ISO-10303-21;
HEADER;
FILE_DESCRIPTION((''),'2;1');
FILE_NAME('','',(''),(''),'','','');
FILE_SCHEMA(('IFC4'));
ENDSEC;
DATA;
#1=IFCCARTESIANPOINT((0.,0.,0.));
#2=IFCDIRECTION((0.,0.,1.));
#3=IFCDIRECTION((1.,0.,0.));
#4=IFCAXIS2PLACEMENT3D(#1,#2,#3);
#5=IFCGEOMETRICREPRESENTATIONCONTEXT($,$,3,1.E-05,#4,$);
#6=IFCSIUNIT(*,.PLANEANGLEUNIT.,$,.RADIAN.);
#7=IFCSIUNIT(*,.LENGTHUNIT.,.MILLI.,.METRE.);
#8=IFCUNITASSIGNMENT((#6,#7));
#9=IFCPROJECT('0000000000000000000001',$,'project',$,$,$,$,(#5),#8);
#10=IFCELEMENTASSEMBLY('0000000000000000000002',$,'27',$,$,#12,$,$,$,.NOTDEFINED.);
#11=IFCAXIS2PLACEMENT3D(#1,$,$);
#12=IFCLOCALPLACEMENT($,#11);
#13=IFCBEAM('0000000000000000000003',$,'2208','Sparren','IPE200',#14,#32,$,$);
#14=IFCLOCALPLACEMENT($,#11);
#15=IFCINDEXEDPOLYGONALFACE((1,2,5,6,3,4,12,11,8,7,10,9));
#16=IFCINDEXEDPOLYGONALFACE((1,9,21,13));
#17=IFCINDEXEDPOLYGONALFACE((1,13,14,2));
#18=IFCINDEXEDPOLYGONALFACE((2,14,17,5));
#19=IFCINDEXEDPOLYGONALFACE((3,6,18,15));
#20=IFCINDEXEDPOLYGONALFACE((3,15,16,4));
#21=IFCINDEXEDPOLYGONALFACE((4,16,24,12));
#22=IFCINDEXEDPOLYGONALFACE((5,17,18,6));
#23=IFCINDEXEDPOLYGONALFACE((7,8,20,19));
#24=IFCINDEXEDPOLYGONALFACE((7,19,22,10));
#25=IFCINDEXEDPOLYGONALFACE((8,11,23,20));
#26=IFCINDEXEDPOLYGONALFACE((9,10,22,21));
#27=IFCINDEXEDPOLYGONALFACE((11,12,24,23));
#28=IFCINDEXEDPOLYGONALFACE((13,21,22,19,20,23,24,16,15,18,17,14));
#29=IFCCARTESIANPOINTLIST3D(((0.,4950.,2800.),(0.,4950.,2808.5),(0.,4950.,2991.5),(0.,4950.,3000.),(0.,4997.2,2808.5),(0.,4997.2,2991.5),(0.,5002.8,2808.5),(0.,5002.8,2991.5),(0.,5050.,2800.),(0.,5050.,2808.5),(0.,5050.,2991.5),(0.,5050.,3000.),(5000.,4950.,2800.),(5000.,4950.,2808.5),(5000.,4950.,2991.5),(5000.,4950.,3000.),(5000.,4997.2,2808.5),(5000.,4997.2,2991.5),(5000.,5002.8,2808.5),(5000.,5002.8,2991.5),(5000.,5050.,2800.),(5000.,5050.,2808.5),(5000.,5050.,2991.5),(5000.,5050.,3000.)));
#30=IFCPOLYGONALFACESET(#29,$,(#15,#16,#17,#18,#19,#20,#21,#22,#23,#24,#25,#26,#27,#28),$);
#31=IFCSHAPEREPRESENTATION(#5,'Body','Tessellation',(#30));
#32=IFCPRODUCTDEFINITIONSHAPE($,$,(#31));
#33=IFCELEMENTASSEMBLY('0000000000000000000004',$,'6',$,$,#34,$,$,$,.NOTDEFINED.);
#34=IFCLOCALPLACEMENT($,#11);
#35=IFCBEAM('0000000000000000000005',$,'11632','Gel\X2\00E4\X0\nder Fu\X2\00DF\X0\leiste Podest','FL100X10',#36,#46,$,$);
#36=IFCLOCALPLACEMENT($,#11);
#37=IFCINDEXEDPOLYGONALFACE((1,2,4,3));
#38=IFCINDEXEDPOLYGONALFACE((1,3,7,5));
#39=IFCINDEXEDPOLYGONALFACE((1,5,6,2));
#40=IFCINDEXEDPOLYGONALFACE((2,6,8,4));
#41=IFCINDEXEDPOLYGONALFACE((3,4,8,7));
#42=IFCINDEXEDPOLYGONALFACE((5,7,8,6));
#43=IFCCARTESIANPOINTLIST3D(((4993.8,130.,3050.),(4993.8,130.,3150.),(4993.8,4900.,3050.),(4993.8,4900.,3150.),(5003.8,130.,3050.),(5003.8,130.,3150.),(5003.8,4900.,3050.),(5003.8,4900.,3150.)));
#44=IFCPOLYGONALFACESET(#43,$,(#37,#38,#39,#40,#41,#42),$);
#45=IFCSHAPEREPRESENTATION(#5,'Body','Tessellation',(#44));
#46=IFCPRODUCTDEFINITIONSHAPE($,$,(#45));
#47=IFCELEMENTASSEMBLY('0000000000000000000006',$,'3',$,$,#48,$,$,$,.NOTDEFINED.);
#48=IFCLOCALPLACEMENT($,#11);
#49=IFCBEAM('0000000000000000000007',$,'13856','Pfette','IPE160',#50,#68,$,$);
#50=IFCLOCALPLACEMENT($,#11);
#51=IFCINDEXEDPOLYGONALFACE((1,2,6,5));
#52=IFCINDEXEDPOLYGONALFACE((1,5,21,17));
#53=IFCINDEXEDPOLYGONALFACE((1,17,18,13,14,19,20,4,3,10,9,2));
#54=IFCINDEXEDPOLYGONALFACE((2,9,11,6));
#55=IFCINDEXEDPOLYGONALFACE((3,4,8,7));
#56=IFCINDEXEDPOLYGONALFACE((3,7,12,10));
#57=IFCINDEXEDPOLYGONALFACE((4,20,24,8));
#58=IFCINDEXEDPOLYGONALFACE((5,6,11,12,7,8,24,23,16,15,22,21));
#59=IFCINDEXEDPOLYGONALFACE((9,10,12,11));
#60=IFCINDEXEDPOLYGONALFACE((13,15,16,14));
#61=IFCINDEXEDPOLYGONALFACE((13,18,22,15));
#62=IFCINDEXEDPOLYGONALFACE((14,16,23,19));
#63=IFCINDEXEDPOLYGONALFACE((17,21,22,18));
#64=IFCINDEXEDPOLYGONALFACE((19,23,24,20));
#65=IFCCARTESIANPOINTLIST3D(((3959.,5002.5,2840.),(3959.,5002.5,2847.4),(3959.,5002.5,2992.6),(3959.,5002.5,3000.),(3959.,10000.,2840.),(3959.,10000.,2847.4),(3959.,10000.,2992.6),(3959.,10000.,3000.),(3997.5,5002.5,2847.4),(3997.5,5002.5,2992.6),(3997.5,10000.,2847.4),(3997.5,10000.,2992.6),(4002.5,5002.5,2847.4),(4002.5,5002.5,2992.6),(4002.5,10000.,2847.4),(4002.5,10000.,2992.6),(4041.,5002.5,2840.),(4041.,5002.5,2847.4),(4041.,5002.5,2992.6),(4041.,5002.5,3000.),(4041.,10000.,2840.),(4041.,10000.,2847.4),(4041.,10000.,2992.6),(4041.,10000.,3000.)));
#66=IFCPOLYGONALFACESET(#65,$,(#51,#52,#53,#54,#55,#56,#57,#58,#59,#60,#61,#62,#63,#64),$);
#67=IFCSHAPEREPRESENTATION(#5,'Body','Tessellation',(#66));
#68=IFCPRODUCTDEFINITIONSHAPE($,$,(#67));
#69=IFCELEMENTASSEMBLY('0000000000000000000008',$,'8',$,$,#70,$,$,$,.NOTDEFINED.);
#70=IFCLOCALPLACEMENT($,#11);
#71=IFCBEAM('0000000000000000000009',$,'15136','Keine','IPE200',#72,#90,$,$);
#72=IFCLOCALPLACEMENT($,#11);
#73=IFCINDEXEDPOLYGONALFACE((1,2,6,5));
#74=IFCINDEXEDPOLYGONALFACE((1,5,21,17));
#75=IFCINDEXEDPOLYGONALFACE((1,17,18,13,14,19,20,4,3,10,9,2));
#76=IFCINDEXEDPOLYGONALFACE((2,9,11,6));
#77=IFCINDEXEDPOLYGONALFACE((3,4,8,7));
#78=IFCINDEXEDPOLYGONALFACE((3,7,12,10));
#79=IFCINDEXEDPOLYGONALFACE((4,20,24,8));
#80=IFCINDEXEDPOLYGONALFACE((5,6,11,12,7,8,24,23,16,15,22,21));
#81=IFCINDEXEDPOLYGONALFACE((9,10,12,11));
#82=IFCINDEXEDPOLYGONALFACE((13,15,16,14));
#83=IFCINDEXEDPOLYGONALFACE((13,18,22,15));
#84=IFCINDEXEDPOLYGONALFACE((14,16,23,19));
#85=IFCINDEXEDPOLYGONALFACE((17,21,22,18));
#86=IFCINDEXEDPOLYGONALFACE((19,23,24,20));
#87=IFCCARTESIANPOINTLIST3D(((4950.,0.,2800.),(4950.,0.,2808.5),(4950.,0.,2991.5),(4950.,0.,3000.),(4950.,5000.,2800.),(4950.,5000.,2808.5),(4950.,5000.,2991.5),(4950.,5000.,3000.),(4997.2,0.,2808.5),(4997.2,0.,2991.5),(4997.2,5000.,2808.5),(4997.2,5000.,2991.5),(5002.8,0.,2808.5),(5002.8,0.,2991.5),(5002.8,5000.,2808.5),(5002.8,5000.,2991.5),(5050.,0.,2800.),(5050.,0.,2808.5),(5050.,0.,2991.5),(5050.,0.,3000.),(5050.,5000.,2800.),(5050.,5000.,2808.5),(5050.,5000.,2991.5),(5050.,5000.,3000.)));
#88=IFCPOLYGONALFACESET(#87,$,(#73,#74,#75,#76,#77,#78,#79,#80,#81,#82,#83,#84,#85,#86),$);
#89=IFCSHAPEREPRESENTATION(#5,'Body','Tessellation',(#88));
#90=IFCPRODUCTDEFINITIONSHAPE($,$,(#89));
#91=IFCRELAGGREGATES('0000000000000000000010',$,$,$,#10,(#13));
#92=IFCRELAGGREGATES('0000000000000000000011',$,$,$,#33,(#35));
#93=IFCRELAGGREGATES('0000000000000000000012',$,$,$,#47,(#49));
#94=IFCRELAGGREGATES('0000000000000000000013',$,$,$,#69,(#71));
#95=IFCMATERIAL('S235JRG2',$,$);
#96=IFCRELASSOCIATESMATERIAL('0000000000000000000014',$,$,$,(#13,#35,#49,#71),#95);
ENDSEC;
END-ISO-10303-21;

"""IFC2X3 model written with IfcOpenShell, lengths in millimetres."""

from ifc_helpers import new_model, si_unit, frame, origin_with_axes, place, context, project, polyline, outline, extrude, material, element, aggregate, save


model = new_model("IFC2X3")

# Units and contexts
context_of_model = context(None, 3, precision=1e-05, world=origin_with_axes())
ifc_project = project(units=[si_unit("PLANEANGLEUNIT", "RADIAN"), si_unit("LENGTHUNIT", "METRE", prefix="MILLI")], contexts=[context_of_model])

# Element assembly, beam
assembly_1_placement = place(None, frame((5000.0, 5000.0, 6000.0), z_axis=(0.0, 0.0, 1.0), x_axis=(-1.0, 0.0, 0.0)))
assembly_1 = element("IfcElementAssembly", 1, at=assembly_1_placement, Name="27", PredefinedType="NOTDEFINED")
ifc_material = material(Name="S235JRG2")
placement_1 = place(None, frame((5000.0, 5000.0, 2900.0), z_axis=(0.0, 0.0, 1.0), x_axis=(-1.0, 0.0, 0.0)))
beam_1_placement = place(placement_1, origin_with_axes())
beam_1 = element("IfcBeam", 2, at=beam_1_placement, material=ifc_material, Name="2208", Description="Sparren", ObjectType="IPE200", context=context_of_model, shape_type="SweptSolid", body=[
    extrude(outline(polyline([(50.0, -100.0), (50.0, -91.5), (2.8, -91.5), (2.8, 91.5), (50.0, 91.5), (50.0, 100.0), (-50.0, 100.0), (-50.0, 91.5), (-2.8, 91.5), (-2.8, -91.5), (-50.0, -91.5), (-50.0, -100.0), (50.0, -100.0), (50.0, -100.0)])), frame((0.0, 0.0, 0.0), z_axis=(1.0, 0.0, 0.0), x_axis=(0.0, 1.0, 0.0)), (0.0, 0.0, 1.0), 5000.0),
])
aggregate(assembly_1, [beam_1])

# Element assembly, beam
assembly_2_placement = place(None, frame((1.2, 5130.0, 6100.0), z_axis=(0.0, 0.0, 1.0), x_axis=(0.0, 1.0, 0.0)))
assembly_2 = element("IfcElementAssembly", 3, at=assembly_2_placement, Name="6", PredefinedType="NOTDEFINED")
placement_2 = place(None, frame((4998.8, 4900.0, 3100.0), z_axis=(0.0, 0.0, 1.0), x_axis=(0.0, -1.0, 0.0)))
beam_2_placement = place(placement_2, origin_with_axes())
beam_2 = element("IfcBeam", 4, at=beam_2_placement, material=ifc_material, Name="11632", Description="Geländer Fußleiste Podest", ObjectType="FL100X10", context=context_of_model, shape_type="SweptSolid", body=[
    extrude(outline(polyline([(5.0, -50.0), (5.0, 50.0), (-5.0, 50.0), (-5.0, -50.0), (5.0, -50.0), (5.0, -50.0)])), frame((0.0, 0.0, 0.0), z_axis=(1.0, 0.0, 0.0), x_axis=(0.0, 1.0, 0.0)), (0.0, 0.0, 1.0), 4770.0),
])
aggregate(assembly_2, [beam_2])

# Element assemblies, beams
assembly_3_placement = place(None, frame((1000.0, 5002.5, 6000.0), z_axis=(0.0, 0.0, 1.0), x_axis=(0.0, 1.0, 0.0)))
assembly_3 = element("IfcElementAssembly", 5, at=assembly_3_placement, Name="3", PredefinedType="NOTDEFINED")
placement_3 = place(None, frame((4000.0, 5002.5, 2920.0), z_axis=(0.0, 0.0, 1.0), x_axis=(0.0, 1.0, 0.0)))
beam_3_placement = place(placement_3, origin_with_axes())
beam_3 = element("IfcBeam", 6, at=beam_3_placement, material=ifc_material, Name="13856", Description="Pfette", ObjectType="IPE160", context=context_of_model, shape_type="SweptSolid", body=[
    extrude(outline(polyline([(41.0, -80.0), (41.0, -72.6), (2.5, -72.6), (2.5, 72.6), (41.0, 72.6), (41.0, 80.0), (-41.0, 80.0), (-41.0, 72.6), (-2.5, 72.6), (-2.5, -72.6), (-41.0, -72.6), (-41.0, -80.0), (41.0, -80.0), (41.0, -80.0)])), frame((0.0, 0.0, 0.0), z_axis=(1.0, 0.0, 0.0), x_axis=(0.0, 1.0, 0.0)), (0.0, 0.0, 1.0), 4997.5),
])
aggregate(assembly_3, [beam_3])
assembly_4_placement = place(None, frame((0.0, 10000.0, 6000.0), z_axis=(0.0, 0.0, 1.0), x_axis=(0.0, -1.0, 0.0)))
assembly_4 = element("IfcElementAssembly", 7, at=assembly_4_placement, Name="8", PredefinedType="NOTDEFINED")
placement_4 = place(None, frame((5000.0, 5000.0, 2900.0), z_axis=(0.0, 0.0, 1.0), x_axis=(0.0, -1.0, 0.0)))
beam_4_placement = place(placement_4, origin_with_axes())
beam_4 = element("IfcBeam", 8, at=beam_4_placement, material=ifc_material, Name="15136", Description="Keine", ObjectType="IPE200", context=context_of_model, shape_type="SweptSolid", body=[
    extrude(outline(polyline([(50.0, -100.0), (50.0, -91.5), (2.8, -91.5), (2.8, 91.5), (50.0, 91.5), (50.0, 100.0), (-50.0, 100.0), (-50.0, 91.5), (-2.8, 91.5), (-2.8, -91.5), (-50.0, -91.5), (-50.0, -100.0), (50.0, -100.0), (50.0, -100.0)])), frame((0.0, 0.0, 0.0), z_axis=(1.0, 0.0, 0.0), x_axis=(0.0, 1.0, 0.0)), (0.0, 0.0, 1.0), 5000.0),
])
aggregate(assembly_4, [beam_4])

save(model, "model.ifc")
